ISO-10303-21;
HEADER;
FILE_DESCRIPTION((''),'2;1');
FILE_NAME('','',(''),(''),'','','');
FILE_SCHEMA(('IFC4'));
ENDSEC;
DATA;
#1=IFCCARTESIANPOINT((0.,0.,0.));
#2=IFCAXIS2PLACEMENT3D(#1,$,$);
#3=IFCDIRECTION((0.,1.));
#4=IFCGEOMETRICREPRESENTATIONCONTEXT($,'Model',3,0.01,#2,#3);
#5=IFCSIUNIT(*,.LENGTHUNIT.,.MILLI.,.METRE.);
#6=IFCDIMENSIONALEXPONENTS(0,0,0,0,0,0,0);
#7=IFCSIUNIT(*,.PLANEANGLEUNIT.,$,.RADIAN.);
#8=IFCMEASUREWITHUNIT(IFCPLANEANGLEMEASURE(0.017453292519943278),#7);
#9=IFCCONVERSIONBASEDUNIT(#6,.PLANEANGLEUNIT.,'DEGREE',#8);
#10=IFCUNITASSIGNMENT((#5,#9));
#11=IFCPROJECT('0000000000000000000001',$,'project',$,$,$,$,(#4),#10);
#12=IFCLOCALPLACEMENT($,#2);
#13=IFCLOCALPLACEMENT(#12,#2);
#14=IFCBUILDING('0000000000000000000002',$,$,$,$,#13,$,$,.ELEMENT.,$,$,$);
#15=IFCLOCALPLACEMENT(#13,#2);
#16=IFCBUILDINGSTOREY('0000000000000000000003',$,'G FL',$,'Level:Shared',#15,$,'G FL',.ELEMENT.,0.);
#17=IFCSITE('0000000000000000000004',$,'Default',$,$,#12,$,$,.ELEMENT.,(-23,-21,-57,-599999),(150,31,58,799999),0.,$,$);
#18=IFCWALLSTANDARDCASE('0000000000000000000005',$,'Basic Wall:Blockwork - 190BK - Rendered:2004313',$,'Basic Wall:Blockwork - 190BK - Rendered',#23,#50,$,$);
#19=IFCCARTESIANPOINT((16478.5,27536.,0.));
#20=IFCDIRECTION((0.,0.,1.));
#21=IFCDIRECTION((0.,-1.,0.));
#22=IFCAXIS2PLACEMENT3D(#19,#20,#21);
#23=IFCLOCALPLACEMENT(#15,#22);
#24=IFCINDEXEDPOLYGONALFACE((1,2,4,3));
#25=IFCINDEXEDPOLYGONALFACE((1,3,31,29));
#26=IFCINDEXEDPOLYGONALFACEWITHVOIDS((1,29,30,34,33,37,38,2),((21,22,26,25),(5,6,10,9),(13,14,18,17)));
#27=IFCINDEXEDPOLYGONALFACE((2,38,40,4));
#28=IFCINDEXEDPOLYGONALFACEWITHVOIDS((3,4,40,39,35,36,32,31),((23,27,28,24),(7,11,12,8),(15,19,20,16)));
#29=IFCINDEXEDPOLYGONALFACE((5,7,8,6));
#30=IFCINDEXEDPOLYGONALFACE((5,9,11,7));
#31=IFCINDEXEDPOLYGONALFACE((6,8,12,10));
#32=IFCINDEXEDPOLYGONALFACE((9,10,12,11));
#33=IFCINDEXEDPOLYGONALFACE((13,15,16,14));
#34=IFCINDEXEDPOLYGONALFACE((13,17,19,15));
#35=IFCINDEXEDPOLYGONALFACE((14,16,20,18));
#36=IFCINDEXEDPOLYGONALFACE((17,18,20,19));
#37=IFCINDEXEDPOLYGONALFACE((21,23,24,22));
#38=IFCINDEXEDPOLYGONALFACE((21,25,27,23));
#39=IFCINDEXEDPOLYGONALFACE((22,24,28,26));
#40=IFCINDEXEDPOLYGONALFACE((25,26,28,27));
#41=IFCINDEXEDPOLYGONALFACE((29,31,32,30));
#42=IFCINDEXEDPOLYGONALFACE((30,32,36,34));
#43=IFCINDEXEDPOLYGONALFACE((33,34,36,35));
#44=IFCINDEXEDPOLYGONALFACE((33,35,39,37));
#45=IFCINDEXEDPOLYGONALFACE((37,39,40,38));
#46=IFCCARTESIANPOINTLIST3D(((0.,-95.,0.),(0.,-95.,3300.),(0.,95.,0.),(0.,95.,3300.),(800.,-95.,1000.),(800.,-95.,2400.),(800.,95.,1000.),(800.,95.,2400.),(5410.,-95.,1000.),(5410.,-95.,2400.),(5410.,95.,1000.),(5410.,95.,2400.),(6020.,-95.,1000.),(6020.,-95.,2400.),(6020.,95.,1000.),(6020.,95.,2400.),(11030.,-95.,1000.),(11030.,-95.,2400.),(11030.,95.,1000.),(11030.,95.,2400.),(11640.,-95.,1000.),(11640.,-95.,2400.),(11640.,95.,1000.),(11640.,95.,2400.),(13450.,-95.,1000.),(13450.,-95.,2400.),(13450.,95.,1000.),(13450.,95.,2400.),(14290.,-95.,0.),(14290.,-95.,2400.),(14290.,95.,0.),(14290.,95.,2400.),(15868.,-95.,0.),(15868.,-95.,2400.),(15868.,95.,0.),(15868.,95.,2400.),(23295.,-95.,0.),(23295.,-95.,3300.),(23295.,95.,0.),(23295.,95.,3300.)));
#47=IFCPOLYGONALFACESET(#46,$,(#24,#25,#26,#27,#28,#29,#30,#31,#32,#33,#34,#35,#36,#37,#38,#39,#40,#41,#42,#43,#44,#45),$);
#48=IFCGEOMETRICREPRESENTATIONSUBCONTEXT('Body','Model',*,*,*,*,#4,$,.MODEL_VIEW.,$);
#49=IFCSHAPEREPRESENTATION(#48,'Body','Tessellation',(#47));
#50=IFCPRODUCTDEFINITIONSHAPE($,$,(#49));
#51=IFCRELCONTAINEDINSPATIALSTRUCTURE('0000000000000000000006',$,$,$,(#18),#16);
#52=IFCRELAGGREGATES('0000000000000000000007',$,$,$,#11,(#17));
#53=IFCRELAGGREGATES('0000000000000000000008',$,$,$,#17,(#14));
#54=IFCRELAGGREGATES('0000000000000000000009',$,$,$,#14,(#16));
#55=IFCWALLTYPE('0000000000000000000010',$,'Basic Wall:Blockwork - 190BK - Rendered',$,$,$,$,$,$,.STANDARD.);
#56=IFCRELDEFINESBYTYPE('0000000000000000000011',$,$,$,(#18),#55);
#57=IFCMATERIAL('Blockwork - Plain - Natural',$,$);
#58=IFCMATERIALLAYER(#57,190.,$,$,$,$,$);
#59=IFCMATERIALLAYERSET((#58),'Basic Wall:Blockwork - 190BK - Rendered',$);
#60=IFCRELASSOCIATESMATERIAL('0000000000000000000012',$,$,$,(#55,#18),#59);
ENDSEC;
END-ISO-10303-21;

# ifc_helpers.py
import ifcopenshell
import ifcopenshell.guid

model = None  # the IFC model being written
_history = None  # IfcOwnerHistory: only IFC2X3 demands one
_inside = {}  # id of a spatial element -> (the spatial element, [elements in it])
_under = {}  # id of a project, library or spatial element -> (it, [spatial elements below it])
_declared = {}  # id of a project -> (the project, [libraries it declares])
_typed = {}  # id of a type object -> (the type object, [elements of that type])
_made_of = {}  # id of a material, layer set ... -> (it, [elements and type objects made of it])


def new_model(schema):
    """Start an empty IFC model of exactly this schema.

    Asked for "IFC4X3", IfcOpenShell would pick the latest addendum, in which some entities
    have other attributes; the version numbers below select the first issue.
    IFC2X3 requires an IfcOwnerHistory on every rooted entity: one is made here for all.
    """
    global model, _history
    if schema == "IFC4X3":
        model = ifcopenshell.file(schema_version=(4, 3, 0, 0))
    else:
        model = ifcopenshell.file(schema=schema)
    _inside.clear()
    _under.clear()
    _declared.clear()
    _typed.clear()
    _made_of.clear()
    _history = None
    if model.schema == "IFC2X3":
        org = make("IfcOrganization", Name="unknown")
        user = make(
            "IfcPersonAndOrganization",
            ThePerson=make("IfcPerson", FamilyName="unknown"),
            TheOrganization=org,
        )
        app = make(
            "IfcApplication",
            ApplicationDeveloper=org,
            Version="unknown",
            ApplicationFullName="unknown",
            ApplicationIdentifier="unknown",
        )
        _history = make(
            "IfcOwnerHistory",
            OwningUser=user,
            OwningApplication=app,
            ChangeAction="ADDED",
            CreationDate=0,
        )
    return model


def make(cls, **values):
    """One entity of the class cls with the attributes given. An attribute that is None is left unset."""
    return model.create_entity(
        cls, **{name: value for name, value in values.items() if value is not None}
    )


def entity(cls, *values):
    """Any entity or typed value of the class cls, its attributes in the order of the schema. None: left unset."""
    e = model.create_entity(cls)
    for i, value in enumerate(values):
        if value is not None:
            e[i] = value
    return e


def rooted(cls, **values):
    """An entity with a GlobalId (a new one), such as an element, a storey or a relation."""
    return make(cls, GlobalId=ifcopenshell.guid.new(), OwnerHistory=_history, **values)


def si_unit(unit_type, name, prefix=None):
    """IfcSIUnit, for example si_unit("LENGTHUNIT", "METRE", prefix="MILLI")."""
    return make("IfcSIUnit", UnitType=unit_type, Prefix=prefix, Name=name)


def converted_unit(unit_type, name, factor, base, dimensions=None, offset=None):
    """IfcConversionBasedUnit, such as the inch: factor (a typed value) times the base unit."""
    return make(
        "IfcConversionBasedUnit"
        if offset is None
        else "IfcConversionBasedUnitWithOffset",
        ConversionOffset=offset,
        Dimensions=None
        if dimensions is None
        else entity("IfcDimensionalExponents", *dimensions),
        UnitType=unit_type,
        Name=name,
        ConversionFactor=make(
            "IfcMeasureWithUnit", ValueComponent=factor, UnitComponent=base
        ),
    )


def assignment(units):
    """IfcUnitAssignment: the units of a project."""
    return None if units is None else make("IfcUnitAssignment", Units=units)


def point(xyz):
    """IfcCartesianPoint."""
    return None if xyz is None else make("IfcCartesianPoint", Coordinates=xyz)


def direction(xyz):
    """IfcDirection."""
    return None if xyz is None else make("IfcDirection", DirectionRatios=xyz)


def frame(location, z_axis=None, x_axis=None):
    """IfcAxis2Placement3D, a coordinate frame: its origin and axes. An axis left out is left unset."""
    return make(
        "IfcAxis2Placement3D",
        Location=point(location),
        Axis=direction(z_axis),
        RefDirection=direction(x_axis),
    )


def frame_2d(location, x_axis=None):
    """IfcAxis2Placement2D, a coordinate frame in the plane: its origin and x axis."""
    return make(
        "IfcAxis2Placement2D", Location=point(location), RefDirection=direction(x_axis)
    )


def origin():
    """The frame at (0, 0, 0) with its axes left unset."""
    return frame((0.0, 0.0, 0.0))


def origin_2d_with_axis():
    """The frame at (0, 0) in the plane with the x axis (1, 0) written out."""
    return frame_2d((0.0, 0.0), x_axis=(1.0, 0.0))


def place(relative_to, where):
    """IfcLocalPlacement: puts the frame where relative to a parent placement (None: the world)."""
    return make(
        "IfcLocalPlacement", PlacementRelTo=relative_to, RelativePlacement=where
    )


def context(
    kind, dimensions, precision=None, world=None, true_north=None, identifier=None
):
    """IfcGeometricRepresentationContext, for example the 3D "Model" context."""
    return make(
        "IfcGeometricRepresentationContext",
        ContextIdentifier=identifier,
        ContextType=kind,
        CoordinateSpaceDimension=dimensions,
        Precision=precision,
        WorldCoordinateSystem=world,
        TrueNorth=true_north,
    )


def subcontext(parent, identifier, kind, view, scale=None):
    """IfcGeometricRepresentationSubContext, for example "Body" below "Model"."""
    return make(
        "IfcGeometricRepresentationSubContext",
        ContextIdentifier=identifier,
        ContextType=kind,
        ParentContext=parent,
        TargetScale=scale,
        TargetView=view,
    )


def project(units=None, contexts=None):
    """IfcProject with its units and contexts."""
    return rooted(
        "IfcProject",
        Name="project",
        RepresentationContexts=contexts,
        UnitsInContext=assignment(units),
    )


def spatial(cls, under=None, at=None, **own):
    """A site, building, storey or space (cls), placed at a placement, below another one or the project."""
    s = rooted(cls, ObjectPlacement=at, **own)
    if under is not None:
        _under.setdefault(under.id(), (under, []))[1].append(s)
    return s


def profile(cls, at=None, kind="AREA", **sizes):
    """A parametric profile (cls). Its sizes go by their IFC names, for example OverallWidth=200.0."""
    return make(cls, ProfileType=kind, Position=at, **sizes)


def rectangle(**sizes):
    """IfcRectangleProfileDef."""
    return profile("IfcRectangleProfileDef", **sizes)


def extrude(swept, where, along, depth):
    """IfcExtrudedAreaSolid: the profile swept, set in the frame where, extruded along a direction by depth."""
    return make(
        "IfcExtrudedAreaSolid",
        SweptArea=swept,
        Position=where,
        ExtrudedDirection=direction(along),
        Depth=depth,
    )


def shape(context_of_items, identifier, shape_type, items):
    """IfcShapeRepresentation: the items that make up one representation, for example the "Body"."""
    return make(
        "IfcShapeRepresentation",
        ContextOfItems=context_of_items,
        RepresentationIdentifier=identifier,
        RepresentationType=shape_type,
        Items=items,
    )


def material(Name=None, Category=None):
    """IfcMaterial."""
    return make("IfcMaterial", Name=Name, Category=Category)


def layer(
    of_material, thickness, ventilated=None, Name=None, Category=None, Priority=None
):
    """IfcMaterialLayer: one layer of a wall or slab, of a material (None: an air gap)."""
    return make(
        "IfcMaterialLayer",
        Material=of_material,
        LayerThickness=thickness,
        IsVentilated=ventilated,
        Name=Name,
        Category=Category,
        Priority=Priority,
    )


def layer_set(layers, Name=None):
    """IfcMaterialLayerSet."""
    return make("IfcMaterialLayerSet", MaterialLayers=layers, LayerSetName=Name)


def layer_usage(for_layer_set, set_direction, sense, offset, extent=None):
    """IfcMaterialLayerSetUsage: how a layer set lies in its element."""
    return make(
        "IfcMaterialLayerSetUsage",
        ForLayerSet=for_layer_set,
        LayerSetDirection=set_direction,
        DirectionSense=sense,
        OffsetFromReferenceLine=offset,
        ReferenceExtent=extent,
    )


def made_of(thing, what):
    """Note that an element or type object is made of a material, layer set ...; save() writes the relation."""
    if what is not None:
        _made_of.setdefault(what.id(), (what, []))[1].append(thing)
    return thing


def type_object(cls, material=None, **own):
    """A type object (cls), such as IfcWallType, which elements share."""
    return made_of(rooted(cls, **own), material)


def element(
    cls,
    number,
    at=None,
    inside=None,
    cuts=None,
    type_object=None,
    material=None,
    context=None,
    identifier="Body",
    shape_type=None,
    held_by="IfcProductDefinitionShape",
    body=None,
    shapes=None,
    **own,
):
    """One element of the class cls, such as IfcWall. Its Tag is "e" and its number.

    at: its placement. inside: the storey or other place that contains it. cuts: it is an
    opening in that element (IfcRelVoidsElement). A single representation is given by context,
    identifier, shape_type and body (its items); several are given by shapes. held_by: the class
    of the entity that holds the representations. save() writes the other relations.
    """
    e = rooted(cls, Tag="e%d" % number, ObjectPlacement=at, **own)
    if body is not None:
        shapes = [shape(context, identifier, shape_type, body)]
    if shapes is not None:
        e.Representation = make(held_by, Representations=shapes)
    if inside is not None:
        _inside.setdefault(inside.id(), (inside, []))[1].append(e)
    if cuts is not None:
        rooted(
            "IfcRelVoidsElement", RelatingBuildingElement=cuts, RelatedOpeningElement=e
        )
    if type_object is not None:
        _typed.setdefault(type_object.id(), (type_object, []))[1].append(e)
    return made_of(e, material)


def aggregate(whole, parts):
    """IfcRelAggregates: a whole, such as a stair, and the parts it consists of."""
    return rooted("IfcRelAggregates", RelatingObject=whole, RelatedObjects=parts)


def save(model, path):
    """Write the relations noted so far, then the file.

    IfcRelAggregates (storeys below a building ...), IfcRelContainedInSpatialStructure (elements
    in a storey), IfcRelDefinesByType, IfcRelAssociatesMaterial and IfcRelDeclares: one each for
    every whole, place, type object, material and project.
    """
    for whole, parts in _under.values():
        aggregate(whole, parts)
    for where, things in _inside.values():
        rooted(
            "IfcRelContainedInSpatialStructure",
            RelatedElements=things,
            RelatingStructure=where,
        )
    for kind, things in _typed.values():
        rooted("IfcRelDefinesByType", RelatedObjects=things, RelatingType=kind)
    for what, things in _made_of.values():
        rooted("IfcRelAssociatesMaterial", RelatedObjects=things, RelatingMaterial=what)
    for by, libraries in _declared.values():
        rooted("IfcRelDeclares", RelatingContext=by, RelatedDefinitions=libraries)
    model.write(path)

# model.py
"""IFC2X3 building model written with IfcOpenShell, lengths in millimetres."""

from ifc_helpers import new_model, entity, si_unit, converted_unit, direction, frame, frame_2d, origin, origin_2d_with_axis, place, context, subcontext, project, spatial, rectangle, extrude, material, layer, layer_set, layer_usage, type_object, element, save


model = new_model("IFC2X3")

# Units and contexts
model_context = context("Model", 3, precision=0.01, world=origin(), true_north=direction((0.0, 1.0)))
body_context = subcontext(model_context, "Body", "Model", "MODEL_VIEW")
ifc_project = project(units=[si_unit("LENGTHUNIT", "METRE", prefix="MILLI"), converted_unit("PLANEANGLEUNIT", "DEGREE", entity("IfcPlaneAngleMeasure", 0.017453292519943278), si_unit("PLANEANGLEUNIT", "RADIAN"), dimensions=[0, 0, 0, 0, 0, 0, 0])], contexts=[model_context])

# Site, building, storey
site_placement = place(None, origin())
site = spatial("IfcSite", under=ifc_project, at=site_placement, Name="Default", CompositionType="ELEMENT", RefLatitude=(-23, -21, -57, -599999), RefLongitude=(150, 31, 58, 799999), RefElevation=0.0)
building_placement = place(site_placement, origin())
building = spatial("IfcBuilding", under=site, at=building_placement, CompositionType="ELEMENT")
storey_placement = place(building_placement, origin())
storey = spatial("IfcBuildingStorey", under=building, at=storey_placement, Name="G FL", ObjectType="Level:Shared", LongName="G FL", CompositionType="ELEMENT", Elevation=0.0)

# Wall, openings
ifc_material_1 = material(Name="Blockwork - Plain - Natural")
ifc_layer_1 = layer(ifc_material_1, 190.0)
ifc_layer_set_1 = layer_set([ifc_layer_1], Name="Basic Wall:Blockwork - 190BK - Rendered")
ifc_layer_usage_1 = layer_usage(ifc_layer_set_1, "AXIS2", "NEGATIVE", 95.0)
wall_type_1 = type_object("IfcWallType", Name="Basic Wall:Blockwork - 190BK - Rendered", PredefinedType="STANDARD", material=ifc_layer_set_1)
wall_1_placement = place(storey_placement, frame((16478.5, 27536.0, 0.0), z_axis=(0.0, 0.0, 1.0), x_axis=(0.0, -1.0, 0.0)))
wall_1 = element("IfcWallStandardCase", 1, at=wall_1_placement, inside=storey, type_object=wall_type_1, material=ifc_layer_usage_1, Name="Basic Wall:Blockwork - 190BK - Rendered:2004313", ObjectType="Basic Wall:Blockwork - 190BK - Rendered", context=body_context, shape_type="SweptSolid", body=[
    extrude(rectangle(XDim=23295.0, YDim=190.0, at=frame_2d((11647.5, 0.0), x_axis=(-1.0, 0.0))), origin(), (0.0, 0.0, 1.0), 3300.0),
])
opening_1_placement = place(wall_1_placement, origin())
element("IfcOpeningElement", 2, at=opening_1_placement, cuts=wall_1, ObjectType="Opening", context=body_context, shape_type="SweptSolid", body=[
    extrude(rectangle(XDim=1400.0, YDim=4610.0, at=origin_2d_with_axis()), frame((3105.0, -247.4, 1700.0), z_axis=(0.0, 1.0, 0.0), x_axis=(0.0, 0.0, 1.0)), (0.0, 0.0, 1.0), 494.8),
])
opening_2_placement = place(wall_1_placement, origin())
element("IfcOpeningElement", 3, at=opening_2_placement, cuts=wall_1, ObjectType="Opening", context=body_context, shape_type="SweptSolid", body=[
    extrude(rectangle(XDim=1400.0, YDim=5010.0, at=frame_2d((0.0, 0.0), x_axis=(0.0, 1.0))), frame((8525.0, -247.4, 1700.0), z_axis=(0.0, 1.0, 0.0), x_axis=(-1.0, 0.0, 0.0)), (0.0, 0.0, 1.0), 494.8),
])
opening_3_placement = place(wall_1_placement, origin())
element("IfcOpeningElement", 4, at=opening_3_placement, cuts=wall_1, ObjectType="Opening", context=body_context, shape_type="SweptSolid", body=[
    extrude(rectangle(XDim=1400.0, YDim=1810.0, at=origin_2d_with_axis()), frame((12545.0, -247.4, 1700.0), z_axis=(0.0, 1.0, 0.0), x_axis=(0.0, 0.0, 1.0)), (0.0, 0.0, 1.0), 494.8),
])
opening_4_placement = place(wall_1_placement, frame((15868.0, 95.0, 0.0)))
element("IfcOpeningElement", 5, at=opening_4_placement, cuts=wall_1, ObjectType="Opening", context=body_context, shape_type="SweptSolid", body=[
    extrude(rectangle(XDim=2400.0, YDim=1578.0, at=frame_2d((1200.0, 789.0), x_axis=(1.0, 0.0))), frame((0.0, 0.0, 0.0), z_axis=(0.0, -1.0, 0.0), x_axis=(0.0, 0.0, 1.0)), (0.0, 0.0, 1.0), 190.0),
])

save(model, "model.ifc")
